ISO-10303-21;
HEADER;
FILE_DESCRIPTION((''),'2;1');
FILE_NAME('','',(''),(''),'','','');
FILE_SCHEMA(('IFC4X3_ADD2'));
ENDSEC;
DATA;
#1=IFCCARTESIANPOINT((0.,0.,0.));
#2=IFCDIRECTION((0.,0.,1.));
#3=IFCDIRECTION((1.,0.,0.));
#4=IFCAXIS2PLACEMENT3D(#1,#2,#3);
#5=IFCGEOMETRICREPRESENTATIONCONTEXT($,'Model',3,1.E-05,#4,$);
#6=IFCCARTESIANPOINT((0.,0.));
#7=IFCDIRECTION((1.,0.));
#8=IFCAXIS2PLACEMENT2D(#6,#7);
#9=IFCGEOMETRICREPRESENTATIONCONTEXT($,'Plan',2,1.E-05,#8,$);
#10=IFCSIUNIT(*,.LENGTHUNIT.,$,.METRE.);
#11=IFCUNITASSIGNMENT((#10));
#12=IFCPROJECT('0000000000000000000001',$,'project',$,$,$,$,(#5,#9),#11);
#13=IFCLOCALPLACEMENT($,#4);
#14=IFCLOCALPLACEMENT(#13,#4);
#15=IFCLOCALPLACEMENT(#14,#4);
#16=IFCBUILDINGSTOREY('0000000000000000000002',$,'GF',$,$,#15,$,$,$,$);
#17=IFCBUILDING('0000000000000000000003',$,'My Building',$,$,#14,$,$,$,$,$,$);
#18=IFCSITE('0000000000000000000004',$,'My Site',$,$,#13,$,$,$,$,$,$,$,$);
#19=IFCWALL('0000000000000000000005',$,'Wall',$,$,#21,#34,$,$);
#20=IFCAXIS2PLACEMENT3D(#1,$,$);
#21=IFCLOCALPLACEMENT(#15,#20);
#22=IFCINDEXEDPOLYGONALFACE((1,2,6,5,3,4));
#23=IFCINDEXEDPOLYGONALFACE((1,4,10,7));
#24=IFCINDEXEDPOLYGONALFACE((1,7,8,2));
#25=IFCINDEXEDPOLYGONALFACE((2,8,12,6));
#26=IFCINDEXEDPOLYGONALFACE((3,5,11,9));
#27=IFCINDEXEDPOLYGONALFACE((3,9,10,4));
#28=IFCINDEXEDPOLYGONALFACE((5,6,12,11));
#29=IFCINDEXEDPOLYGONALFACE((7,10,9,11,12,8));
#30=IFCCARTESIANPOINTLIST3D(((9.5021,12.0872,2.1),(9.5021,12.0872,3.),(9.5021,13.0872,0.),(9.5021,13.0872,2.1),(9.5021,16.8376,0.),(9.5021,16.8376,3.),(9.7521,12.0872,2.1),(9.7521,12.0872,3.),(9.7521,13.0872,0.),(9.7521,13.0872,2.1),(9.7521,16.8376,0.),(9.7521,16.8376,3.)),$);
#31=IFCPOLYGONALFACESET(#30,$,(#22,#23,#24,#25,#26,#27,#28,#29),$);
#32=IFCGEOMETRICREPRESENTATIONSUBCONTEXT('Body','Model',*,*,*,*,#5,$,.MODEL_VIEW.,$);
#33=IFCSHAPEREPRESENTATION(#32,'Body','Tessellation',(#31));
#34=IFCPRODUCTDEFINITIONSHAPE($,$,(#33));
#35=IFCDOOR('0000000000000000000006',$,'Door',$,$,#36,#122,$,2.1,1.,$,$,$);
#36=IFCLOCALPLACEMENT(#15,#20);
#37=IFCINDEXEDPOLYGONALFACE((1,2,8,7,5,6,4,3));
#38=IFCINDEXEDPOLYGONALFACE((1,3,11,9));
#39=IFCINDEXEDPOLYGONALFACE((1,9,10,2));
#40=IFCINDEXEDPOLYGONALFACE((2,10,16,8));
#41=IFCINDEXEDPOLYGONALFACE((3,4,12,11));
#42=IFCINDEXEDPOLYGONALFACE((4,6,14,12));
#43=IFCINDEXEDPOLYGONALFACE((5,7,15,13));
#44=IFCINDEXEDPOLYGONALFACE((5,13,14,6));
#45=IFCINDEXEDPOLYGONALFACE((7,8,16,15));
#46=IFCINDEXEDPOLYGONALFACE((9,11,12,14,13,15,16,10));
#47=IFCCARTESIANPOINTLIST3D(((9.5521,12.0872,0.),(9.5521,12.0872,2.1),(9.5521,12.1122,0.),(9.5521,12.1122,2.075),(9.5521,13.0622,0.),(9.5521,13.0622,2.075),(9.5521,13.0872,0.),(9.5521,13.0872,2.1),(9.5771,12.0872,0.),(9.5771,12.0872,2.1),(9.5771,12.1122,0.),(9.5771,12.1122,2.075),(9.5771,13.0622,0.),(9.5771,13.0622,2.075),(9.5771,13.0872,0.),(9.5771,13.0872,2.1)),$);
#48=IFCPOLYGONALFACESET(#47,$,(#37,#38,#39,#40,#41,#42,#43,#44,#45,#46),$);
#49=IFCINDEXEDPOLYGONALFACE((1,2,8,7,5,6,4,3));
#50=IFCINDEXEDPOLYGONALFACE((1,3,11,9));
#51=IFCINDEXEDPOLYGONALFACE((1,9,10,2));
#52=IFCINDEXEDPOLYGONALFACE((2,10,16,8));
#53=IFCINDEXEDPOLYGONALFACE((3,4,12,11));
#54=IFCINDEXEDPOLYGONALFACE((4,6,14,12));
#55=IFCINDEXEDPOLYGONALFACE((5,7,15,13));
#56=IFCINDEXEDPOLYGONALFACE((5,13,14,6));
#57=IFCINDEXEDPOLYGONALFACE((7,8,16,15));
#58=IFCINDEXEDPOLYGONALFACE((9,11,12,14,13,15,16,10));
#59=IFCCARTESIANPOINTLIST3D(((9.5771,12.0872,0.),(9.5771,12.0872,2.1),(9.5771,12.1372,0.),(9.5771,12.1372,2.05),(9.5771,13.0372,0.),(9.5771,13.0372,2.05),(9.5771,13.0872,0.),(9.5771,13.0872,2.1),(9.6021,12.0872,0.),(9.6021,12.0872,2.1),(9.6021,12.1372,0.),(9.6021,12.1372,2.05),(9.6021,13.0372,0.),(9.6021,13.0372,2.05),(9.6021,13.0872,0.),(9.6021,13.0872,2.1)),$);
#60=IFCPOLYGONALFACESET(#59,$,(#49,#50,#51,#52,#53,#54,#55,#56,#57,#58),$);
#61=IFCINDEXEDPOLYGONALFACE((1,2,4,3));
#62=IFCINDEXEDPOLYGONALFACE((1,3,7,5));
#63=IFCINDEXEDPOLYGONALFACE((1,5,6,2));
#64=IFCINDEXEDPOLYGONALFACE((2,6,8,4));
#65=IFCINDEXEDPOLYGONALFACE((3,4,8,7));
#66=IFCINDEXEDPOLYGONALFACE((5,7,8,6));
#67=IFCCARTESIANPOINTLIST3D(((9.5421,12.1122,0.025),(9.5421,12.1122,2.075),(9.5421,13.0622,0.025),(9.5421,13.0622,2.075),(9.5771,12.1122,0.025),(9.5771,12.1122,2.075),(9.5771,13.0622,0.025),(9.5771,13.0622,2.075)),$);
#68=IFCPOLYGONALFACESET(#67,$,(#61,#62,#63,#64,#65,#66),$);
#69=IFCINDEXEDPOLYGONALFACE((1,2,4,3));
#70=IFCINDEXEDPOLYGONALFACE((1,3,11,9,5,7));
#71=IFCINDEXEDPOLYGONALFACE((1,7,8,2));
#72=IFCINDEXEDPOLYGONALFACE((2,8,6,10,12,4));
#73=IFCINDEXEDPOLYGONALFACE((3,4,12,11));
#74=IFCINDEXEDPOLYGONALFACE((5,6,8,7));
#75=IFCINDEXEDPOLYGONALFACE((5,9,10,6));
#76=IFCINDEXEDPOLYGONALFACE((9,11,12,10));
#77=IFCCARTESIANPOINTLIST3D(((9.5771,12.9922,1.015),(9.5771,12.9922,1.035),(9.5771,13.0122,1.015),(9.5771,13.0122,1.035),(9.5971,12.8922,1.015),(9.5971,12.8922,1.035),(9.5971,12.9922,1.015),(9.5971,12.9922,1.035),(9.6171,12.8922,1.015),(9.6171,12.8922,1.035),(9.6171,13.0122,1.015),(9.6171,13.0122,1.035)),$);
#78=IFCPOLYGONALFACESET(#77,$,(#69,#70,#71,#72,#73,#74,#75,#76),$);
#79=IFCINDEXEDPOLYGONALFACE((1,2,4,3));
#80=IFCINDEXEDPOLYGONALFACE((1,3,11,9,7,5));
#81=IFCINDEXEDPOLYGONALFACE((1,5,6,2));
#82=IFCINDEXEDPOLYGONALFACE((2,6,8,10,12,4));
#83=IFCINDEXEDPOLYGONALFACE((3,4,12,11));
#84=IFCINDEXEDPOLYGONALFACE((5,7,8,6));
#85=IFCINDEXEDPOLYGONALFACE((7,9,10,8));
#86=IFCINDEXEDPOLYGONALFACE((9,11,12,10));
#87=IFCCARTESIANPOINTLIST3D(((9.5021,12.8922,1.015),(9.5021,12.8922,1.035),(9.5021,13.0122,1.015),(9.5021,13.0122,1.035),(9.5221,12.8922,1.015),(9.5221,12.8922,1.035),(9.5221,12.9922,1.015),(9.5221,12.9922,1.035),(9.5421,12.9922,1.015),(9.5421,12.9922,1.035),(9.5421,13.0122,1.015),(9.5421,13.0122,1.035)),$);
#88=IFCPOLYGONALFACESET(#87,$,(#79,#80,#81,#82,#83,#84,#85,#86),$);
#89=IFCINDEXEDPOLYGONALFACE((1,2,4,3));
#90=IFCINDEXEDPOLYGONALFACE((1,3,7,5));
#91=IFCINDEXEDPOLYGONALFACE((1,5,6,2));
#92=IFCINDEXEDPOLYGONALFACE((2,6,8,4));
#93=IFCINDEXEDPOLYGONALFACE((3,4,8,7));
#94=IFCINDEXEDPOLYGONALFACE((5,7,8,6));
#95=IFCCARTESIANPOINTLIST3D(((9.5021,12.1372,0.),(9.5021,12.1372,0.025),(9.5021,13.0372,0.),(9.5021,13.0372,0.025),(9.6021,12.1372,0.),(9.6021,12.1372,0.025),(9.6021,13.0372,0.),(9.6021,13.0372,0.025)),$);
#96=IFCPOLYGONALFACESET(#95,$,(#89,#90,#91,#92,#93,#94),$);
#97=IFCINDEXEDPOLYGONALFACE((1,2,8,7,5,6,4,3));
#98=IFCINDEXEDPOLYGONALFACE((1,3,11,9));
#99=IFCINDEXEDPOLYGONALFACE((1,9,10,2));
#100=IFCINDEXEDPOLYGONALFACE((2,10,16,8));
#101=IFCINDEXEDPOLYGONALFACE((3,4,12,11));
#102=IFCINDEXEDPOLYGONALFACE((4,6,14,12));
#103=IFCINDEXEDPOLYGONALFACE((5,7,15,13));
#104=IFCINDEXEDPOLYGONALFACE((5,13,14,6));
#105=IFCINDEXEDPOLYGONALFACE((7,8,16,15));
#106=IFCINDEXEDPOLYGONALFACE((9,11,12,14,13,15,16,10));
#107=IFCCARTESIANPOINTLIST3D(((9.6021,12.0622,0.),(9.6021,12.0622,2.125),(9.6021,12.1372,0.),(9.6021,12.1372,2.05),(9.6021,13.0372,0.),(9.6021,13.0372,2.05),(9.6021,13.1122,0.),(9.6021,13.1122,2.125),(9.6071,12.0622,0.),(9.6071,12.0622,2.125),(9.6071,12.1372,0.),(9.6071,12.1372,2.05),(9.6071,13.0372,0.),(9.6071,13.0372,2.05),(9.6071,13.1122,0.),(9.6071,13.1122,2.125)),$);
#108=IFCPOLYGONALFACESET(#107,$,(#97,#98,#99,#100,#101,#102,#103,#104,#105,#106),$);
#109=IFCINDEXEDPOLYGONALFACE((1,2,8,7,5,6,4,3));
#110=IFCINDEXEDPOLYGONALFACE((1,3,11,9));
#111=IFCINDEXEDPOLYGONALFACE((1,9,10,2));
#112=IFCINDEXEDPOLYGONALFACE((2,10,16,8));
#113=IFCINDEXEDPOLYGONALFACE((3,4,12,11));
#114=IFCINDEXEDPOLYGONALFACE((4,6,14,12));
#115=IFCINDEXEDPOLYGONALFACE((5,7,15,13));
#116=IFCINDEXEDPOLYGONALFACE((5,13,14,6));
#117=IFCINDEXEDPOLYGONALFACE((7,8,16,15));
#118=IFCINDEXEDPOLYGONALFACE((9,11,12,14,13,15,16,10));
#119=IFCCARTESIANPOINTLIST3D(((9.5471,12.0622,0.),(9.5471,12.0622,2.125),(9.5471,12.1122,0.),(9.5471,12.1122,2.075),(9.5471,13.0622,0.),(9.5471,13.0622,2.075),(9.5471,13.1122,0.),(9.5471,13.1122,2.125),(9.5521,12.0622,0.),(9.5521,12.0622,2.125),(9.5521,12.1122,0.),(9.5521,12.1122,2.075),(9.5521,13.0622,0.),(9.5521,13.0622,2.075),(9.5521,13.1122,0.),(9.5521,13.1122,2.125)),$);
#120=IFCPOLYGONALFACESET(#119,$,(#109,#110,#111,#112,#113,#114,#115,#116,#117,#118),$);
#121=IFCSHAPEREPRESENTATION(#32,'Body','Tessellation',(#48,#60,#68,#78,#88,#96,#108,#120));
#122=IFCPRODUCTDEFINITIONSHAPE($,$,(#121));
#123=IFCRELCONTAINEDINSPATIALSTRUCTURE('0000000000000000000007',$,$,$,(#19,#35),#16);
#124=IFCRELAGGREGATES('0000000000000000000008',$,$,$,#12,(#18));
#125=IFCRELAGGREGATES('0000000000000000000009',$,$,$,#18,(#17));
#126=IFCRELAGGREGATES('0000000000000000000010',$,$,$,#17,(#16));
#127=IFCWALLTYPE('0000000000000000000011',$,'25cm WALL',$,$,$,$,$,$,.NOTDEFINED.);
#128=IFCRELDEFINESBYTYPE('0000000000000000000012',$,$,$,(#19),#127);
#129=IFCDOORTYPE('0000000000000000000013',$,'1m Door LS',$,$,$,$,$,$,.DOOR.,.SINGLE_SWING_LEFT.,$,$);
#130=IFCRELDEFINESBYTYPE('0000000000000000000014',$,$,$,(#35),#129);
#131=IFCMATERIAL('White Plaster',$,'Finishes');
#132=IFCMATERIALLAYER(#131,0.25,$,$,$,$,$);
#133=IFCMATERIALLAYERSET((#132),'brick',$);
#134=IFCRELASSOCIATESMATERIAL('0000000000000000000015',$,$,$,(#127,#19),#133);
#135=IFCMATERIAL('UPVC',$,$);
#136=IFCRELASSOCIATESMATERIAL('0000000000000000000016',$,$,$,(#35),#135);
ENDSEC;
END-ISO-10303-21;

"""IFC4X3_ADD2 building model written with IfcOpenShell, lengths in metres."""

from ifc_helpers import new_model, entity, si_unit, frame, origin_with_axes, origin_2d_with_axis, place, context, subcontext, project, spatial, line, indexed_curve, outline, extrude, shape, source, transform, mapped, material, layer, layer_set, layer_usage, type_object, type_shapes, element, fill, save


model = new_model("IFC4X3_ADD2")

# Units and contexts
model_context = context("Model", 3, precision=1e-05, world=origin_with_axes())
plan_context = context("Plan", 2, precision=1e-05, world=origin_2d_with_axis())
body_context_1 = subcontext(model_context, "Body", "Model", "MODEL_VIEW")
body_context_2 = subcontext(plan_context, "Body", "Plan", "PLAN_VIEW")
ifc_project = project(units=[si_unit("LENGTHUNIT", "METRE")], contexts=[model_context, plan_context])

# Site, building, storey
site_placement = place(None, origin_with_axes())
site = spatial("IfcSite", under=ifc_project, at=site_placement, Name="My Site")
building_placement = place(site_placement, origin_with_axes())
building = spatial("IfcBuilding", under=site, at=building_placement, Name="My Building")
storey_placement = place(building_placement, origin_with_axes())
storey = spatial("IfcBuildingStorey", under=building, at=storey_placement, Name="GF")

# Shared definitions
ifc_material_1 = material(Name="White Plaster", Category="Finishes")

# Wall, opening, door
ifc_layer_1 = layer(ifc_material_1, 0.25)
ifc_layer_set_1 = layer_set([ifc_layer_1], Name="brick")
ifc_layer_usage_1 = layer_usage(ifc_layer_set_1, "AXIS2", "POSITIVE", 0.0)
wall_type_1 = type_object("IfcWallType", Name="25cm WALL", PredefinedType="NOTDEFINED", material=ifc_layer_set_1)
wall_1_placement = place(storey_placement, frame((9.5021, 16.8376, 0.0), z_axis=(0.0, 0.0, 1.0), x_axis=(0.0, -1.0, 0.0)))
wall_1 = element("IfcWall", 1, at=wall_1_placement, inside=storey, type_object=wall_type_1, material=ifc_layer_usage_1, Name="Wall", context=body_context_1, shape_type="SweptSolid", body=[
    extrude(outline(indexed_curve([(0.0, 0.0), (0.0, 0.25), (4.7504, 0.25), (4.7504, 0.0)], segments=[line(1, 2, 3, 4, 1)])), origin_with_axes(), (0.0, 0.0, 1.0), 3.0),
])
shared_shape_1 = source(origin_with_axes(), body_context_1, "Body", "SweptSolid", [
    extrude(outline(indexed_curve([(0.0, 0.0), (1.0, 0.0), (1.0, 2.1), (0.0, 2.1)], segments=[line(1, 2, 3, 4, 1)])), frame((0.0, -0.6, 0.0), z_axis=(0.0, -1.0, 0.0), x_axis=(1.0, 0.0, 0.0)), (0.0, 0.0, -1.0), 1.2),
])
opening_1_placement = place(wall_1_placement, frame((4.7504, 0.25, 0.0), z_axis=(0.0, 0.0, 1.0), x_axis=(-1.0, 0.0, 0.0)))
opening_1 = element("IfcOpeningElement", 2, at=opening_1_placement, cuts=wall_1, PredefinedType="OPENING", context=body_context_1, shape_type="MappedRepresentation", body=[
    mapped(shared_shape_1, transform((0.0, 0.0, 0.0), x_axis=(1.0, 0.0, 0.0), y_axis=(0.0, 1.0, 0.0), z_axis=(0.0, 0.0, 1.0), scale=1.0)),
])
ifc_material_2 = material(Name="UPVC")
door_type_1 = type_object("IfcDoorType", Name="1m Door LS", OperationType="SINGLE_SWING_LEFT", PredefinedType="DOOR")
shared_shape_2 = source(origin_with_axes(), body_context_1, "Body", "SweptSolid", [
    extrude(outline(indexed_curve([(0.0, 0.0), (0.0, 2.1), (1.0, 2.1), (1.0, 0.0), (0.975, 0.0), (0.975, 2.075), (0.025, 2.075), (0.025, 0.0)], segments=[line(1, 2, 3, 4, 5, 6, 7, 8, 1)])), frame((0.0, 0.025, 0.0), z_axis=(0.0, -1.0, 0.0), x_axis=(1.0, 0.0, 0.0)), (0.0, 0.0, -1.0), 0.025),
    extrude(outline(indexed_curve([(0.0, 0.0), (0.0, 2.1), (1.0, 2.1), (1.0, 0.0), (0.95, 0.0), (0.95, 2.05), (0.05, 2.05), (0.05, 0.0)], segments=[line(1, 2, 3, 4, 5, 6, 7, 8, 1)])), frame((0.0, 0.0, 0.0), z_axis=(0.0, -1.0, 0.0), x_axis=(1.0, 0.0, 0.0)), (0.0, 0.0, -1.0), 0.025),
    extrude(outline(indexed_curve([(0.0, 0.0), (0.95, 0.0), (0.95, 0.035), (0.0, 0.035)], segments=[line(1, 2, 3, 4, 1)])), frame((0.025, 0.025, 0.025), z_axis=(0.0, 0.0, 1.0), x_axis=(1.0, 0.0, 0.0)), (0.0, 0.0, 1.0), 2.05),
    extrude(outline(indexed_curve([(0.0, 0.0), (0.0, -0.04), (-0.12, -0.04), (-0.12, -0.02), (-0.02, -0.02), (-0.02, 0.0)], segments=[line(1, 2, 3, 4, 5, 6, 1)])), frame((0.925, 0.025, 1.015), z_axis=(0.0, 0.0, 1.0), x_axis=(1.0, 0.0, 0.0)), (0.0, 0.0, 1.0), 0.02),
    extrude(outline(indexed_curve([(0.0, 0.0), (0.0, 0.04), (-0.12, 0.04), (-0.12, 0.02), (-0.02, 0.02), (-0.02, 0.0)], segments=[line(1, 2, 3, 4, 5, 6, 1)])), frame((0.925, 0.06, 1.015), z_axis=(0.0, 0.0, 1.0), x_axis=(1.0, 0.0, 0.0)), (0.0, 0.0, 1.0), 0.02),
    extrude(outline(indexed_curve([(0.0, 0.0), (0.9, 0.0), (0.9, 0.1), (0.0, 0.1)], segments=[line(1, 2, 3, 4, 1)])), frame((0.05, 0.0, 0.0), z_axis=(0.0, 0.0, 1.0), x_axis=(1.0, 0.0, 0.0)), (0.0, 0.0, 1.0), 0.025),
    extrude(outline(indexed_curve([(0.0, 0.0), (0.0, 2.125), (1.05, 2.125), (1.05, 0.0), (0.975, 0.0), (0.975, 2.05), (0.075, 2.05), (0.075, 0.0)], segments=[line(1, 2, 3, 4, 5, 6, 7, 8, 1)])), frame((-0.025, -0.005, 0.0), z_axis=(0.0, -1.0, 0.0), x_axis=(1.0, 0.0, 0.0)), (0.0, 0.0, -1.0), 0.005),
    extrude(outline(indexed_curve([(0.0, 0.0), (0.0, 2.125), (1.05, 2.125), (1.05, 0.0), (1.0, 0.0), (1.0, 2.075), (0.05, 2.075), (0.05, 0.0)], segments=[line(1, 2, 3, 4, 5, 6, 7, 8, 1)])), frame((-0.025, 0.05, 0.0), z_axis=(0.0, -1.0, 0.0), x_axis=(1.0, 0.0, 0.0)), (0.0, 0.0, -1.0), 0.005),
])
shared_shape_3 = source(origin_with_axes(), body_context_2, "Body", "Curve2D", [
    entity("IfcIndexedPolyCurve", entity("IfcCartesianPointList2D", [[0.0, 0.0], [0.0, 0.05], [0.025, 0.05], [0.025, 0.025], [0.05, 0.025], [0.05, 0.0]]), [entity("IfcLineIndex", [1, 2, 3, 4, 5, 6, 1])]),
    entity("IfcIndexedPolyCurve", entity("IfcCartesianPointList2D", [[1.0, 0.0], [1.0, 0.05], [0.975, 0.05], [0.975, 0.025], [0.95, 0.025], [0.95, 0.0]]), [entity("IfcLineIndex", [1, 2, 3, 4, 5, 6, 1])]),
    entity("IfcTrimmedCurve", entity("IfcEllipse", entity("IfcAxis2Placement2D", entity("IfcCartesianPoint", [0.06, 0.05]), entity("IfcDirection", [1.0, 0.0])), 0.915, 0.95), [entity("IfcCartesianPoint", [0.975, 0.05])], [entity("IfcCartesianPoint", [0.06, 1.0])], True, "CARTESIAN"),
    entity("IfcIndexedPolyCurve", entity("IfcCartesianPointList2D", [[0.025, 0.05], [0.06, 0.05], [0.06, 1.0], [0.025, 1.0]]), [entity("IfcLineIndex", [1, 2, 3, 4, 1])]),
])
type_shapes(door_type_1, [shared_shape_2, shared_shape_3])
door_1_placement = place(opening_1_placement, frame((0.0, 0.15, 0.0), z_axis=(0.0, 0.0, 1.0), x_axis=(1.0, 0.0, 0.0)))
door_1 = element("IfcDoor", 3, at=door_1_placement, inside=storey, type_object=door_type_1, material=ifc_material_2, Name="Door", OverallHeight=2.1, OverallWidth=1.0, shapes=[
    shape(body_context_1, "Body", "MappedRepresentation", [mapped(shared_shape_2, transform((0.0, 0.0, 0.0), x_axis=(1.0, 0.0, 0.0), y_axis=(0.0, 1.0, 0.0), z_axis=(0.0, 0.0, 1.0), scale=1.0))]),
    shape(body_context_2, "Body", "MappedRepresentation", [mapped(shared_shape_3, transform((0.0, 0.0, 0.0), x_axis=(1.0, 0.0, 0.0), y_axis=(0.0, 1.0, 0.0), z_axis=(0.0, 0.0, 1.0), scale=1.0))]),
])
fill(opening_1, door_1)

save(model, "model.ifc")
